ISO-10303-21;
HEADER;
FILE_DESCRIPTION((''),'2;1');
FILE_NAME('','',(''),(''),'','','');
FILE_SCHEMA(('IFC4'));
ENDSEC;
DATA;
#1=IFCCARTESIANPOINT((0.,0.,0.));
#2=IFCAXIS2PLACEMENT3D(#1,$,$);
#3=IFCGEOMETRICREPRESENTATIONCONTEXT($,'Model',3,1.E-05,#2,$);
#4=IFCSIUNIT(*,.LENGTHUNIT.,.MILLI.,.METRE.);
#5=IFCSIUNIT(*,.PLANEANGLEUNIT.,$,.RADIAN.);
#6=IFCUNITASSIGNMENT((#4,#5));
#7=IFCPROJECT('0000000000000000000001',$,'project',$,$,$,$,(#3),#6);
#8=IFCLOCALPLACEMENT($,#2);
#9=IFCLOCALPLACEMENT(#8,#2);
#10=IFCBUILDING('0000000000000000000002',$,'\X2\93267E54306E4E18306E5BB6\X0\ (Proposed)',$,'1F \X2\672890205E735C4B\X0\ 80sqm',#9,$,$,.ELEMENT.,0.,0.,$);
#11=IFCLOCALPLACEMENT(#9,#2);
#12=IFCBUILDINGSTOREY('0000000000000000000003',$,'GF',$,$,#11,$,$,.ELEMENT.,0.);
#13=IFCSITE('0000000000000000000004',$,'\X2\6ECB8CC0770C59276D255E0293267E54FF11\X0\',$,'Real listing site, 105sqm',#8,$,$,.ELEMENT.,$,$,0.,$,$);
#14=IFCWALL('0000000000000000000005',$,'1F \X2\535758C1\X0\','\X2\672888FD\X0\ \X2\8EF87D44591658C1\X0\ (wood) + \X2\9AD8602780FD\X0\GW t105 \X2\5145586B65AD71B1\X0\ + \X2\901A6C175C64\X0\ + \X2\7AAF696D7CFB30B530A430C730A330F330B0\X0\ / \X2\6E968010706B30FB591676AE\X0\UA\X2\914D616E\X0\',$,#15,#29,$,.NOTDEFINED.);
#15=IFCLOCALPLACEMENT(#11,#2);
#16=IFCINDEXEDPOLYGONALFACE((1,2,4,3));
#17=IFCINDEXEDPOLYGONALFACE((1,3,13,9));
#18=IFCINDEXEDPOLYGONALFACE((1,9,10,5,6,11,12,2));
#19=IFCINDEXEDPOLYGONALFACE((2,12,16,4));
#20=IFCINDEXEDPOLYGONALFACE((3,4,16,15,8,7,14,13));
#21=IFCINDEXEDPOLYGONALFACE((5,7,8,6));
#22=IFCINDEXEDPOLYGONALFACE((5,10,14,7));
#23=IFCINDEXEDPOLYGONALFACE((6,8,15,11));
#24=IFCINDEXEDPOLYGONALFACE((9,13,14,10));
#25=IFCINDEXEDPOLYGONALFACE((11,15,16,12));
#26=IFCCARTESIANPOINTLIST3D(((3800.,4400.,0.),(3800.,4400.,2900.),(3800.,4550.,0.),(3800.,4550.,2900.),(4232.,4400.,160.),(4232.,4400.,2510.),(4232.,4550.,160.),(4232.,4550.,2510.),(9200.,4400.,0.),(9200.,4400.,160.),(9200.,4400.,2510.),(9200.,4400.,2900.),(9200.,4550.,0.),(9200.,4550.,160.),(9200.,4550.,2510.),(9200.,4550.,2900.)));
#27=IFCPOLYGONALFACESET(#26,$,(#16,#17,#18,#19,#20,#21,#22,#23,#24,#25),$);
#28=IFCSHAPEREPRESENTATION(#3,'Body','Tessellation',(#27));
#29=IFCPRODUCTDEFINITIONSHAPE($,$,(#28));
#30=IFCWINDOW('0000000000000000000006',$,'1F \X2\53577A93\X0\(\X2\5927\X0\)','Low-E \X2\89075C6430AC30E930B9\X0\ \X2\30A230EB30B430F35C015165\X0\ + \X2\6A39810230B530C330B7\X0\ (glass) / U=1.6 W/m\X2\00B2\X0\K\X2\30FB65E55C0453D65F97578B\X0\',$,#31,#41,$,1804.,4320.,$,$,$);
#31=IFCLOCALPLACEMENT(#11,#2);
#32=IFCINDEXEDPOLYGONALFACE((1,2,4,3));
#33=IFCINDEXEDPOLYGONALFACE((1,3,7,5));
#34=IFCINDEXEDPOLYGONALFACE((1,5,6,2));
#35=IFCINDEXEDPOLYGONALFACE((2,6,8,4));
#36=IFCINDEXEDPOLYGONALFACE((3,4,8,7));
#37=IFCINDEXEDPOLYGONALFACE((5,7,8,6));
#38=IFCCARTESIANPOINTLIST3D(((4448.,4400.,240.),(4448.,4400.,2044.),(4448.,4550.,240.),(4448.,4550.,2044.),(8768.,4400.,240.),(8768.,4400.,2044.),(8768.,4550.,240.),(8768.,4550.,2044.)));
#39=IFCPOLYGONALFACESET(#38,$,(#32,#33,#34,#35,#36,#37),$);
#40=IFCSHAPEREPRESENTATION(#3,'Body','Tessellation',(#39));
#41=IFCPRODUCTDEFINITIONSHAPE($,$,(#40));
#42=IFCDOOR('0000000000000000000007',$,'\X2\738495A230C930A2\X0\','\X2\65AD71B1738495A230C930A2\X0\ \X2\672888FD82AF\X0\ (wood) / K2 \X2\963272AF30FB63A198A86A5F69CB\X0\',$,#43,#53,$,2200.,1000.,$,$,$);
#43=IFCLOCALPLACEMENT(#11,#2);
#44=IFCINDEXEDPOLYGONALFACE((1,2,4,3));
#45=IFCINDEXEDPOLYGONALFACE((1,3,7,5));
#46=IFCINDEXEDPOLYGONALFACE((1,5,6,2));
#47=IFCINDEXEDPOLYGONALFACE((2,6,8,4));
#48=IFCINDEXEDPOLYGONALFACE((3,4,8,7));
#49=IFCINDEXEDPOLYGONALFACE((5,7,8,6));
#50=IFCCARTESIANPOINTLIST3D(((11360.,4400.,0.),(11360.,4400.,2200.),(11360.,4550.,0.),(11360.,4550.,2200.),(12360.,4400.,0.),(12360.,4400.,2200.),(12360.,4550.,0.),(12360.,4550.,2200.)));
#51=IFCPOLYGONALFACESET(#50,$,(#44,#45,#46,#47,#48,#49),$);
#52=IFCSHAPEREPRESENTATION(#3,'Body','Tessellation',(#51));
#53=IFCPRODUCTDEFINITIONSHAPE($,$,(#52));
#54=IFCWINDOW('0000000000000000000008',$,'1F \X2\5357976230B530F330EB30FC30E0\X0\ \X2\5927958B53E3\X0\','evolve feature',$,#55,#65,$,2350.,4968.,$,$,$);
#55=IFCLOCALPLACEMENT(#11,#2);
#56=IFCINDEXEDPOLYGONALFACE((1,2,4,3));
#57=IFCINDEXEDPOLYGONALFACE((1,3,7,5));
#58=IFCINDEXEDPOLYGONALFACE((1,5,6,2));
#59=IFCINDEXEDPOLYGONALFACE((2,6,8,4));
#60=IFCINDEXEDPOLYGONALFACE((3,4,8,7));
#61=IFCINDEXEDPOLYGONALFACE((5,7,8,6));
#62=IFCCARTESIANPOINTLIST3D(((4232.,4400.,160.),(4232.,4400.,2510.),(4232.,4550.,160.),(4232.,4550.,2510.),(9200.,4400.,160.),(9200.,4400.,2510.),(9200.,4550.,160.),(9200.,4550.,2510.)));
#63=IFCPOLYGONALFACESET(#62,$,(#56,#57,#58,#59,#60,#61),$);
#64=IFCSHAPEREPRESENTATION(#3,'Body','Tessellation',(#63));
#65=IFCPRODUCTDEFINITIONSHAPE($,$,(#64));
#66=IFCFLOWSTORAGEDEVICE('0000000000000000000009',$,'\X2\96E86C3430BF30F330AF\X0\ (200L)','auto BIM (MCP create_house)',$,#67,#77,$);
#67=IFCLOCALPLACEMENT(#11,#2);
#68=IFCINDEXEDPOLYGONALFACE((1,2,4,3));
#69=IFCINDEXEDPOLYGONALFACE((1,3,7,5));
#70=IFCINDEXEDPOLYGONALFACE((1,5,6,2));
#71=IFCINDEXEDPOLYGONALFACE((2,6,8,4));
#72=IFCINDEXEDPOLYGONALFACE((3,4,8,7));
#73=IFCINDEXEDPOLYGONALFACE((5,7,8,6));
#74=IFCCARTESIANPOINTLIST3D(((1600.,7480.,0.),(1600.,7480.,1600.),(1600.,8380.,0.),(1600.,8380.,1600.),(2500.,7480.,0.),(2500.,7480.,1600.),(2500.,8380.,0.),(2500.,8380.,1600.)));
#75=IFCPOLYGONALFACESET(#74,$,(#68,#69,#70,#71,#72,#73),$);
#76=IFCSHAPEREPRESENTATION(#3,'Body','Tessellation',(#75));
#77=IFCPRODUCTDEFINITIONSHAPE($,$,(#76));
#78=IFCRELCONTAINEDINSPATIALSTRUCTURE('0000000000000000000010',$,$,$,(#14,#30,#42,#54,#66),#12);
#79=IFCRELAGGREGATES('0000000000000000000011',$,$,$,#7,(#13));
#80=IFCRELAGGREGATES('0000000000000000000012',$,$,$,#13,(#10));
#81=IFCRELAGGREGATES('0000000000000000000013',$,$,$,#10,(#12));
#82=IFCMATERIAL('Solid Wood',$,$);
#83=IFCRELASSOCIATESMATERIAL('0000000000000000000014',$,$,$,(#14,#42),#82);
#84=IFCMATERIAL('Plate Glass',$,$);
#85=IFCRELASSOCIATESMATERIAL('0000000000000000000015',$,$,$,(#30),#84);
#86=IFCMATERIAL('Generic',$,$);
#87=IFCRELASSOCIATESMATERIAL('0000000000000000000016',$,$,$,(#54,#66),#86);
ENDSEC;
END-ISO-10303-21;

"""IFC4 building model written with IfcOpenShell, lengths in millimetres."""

from ifc_helpers import new_model, si_unit, frame, frame_2d, origin, place, context, project, spatial, rectangle, extrude, material, element, fill, save


model = new_model("IFC4")

# Units and contexts
model_context = context("Model", 3, precision=1e-05, world=origin())
ifc_project = project(units=[si_unit("LENGTHUNIT", "METRE", prefix="MILLI"), si_unit("PLANEANGLEUNIT", "RADIAN")], contexts=[model_context])

# Site, building, storey
site_placement = place(None, origin())
site = spatial("IfcSite", under=ifc_project, at=site_placement, Name="滋賀県大津市錦織１", ObjectType="Real listing site, 105sqm", CompositionType="ELEMENT", RefElevation=0.0)
building_placement = place(site_placement, origin())
building = spatial("IfcBuilding", under=site, at=building_placement, Name="錦織の丘の家 (Proposed)", ObjectType="1F 木造平屋 80sqm", CompositionType="ELEMENT", ElevationOfRefHeight=0.0, ElevationOfTerrain=0.0)
storey_placement = place(building_placement, origin())
storey = spatial("IfcBuildingStorey", under=building, at=storey_placement, Name="GF", CompositionType="ELEMENT", Elevation=0.0)

# Shared definitions
ifc_material_1 = material(Name="Solid Wood")

# Wall, openings, windows, door
wall_1_placement = place(storey_placement, frame((1900.0, 2200.0, 0.0)))
wall_1 = element("IfcWall", 1, at=wall_1_placement, inside=storey, material=ifc_material_1, Name="1F 南壁", Description="木製 軸組外壁 (wood) + 高性能GW t105 充填断熱 + 通気層 + 窯業系サイディング / 準耐火・外皮UA配慮", PredefinedType="NOTDEFINED", context=model_context, shape_type="SweptSolid", body=[
    extrude(rectangle(XDim=5400.0, YDim=150.0, at=frame_2d((2700.0, 75.0))), frame((1900.0, 2200.0, 0.0)), (0.0, 0.0, 1.0), 2900.0),
])
opening_1_placement = place(storey_placement, frame((2224.0, 2200.0, 120.0)))
opening_1 = element("IfcOpeningElement", 2, at=opening_1_placement, cuts=wall_1, PredefinedType="NOTDEFINED", context=model_context, shape_type="SweptSolid", body=[
    extrude(rectangle(XDim=4320.0, YDim=150.0, at=frame_2d((2160.0, 75.0))), frame((2224.0, 2200.0, 120.0)), (0.0, 0.0, 1.0), 1804.0),
])
opening_2_placement = place(storey_placement, frame((5680.0, 2200.0, 0.0)))
opening_2 = element("IfcOpeningElement", 3, at=opening_2_placement, cuts=wall_1, PredefinedType="NOTDEFINED", context=model_context, shape_type="SweptSolid", body=[
    extrude(rectangle(XDim=1000.0, YDim=150.0, at=frame_2d((500.0, 75.0))), frame((5680.0, 2200.0, 0.0)), (0.0, 0.0, 1.0), 2200.0),
])
opening_3_placement = place(storey_placement, frame((2116.0, 2200.0, 80.0)))
opening_3 = element("IfcOpeningElement", 4, at=opening_3_placement, cuts=wall_1, PredefinedType="NOTDEFINED", context=model_context, shape_type="SweptSolid", body=[
    extrude(rectangle(XDim=4968.0, YDim=150.0, at=frame_2d((2484.0, 75.0))), frame((2116.0, 2200.0, 80.0)), (0.0, 0.0, 1.0), 2350.0),
])
ifc_material_2 = material(Name="Plate Glass")
window_1_placement = place(storey_placement, frame((2224.0, 2200.0, 120.0)))
window_1 = element("IfcWindow", 5, at=window_1_placement, inside=storey, material=ifc_material_2, Name="1F 南窓(大)", Description="Low-E 複層ガラス アルゴン封入 + 樹脂サッシ (glass) / U=1.6 W/m²K・日射取得型", OverallHeight=1804.0, OverallWidth=4320.0, context=model_context, shape_type="SweptSolid", body=[
    extrude(rectangle(XDim=4320.0, YDim=150.0, at=frame_2d((2160.0, 75.0))), frame((2224.0, 2200.0, 120.0)), (0.0, 0.0, 1.0), 1804.0),
])
fill(opening_1, window_1)
door_1_placement = place(storey_placement, frame((5680.0, 2200.0, 0.0)))
door_1 = element("IfcDoor", 6, at=door_1_placement, inside=storey, material=ifc_material_1, Name="玄関ドア", Description="断熱玄関ドア 木製芯 (wood) / K2 防犯・採風機構", OverallHeight=2200.0, OverallWidth=1000.0, context=model_context, shape_type="SweptSolid", body=[
    extrude(rectangle(XDim=1000.0, YDim=150.0, at=frame_2d((500.0, 75.0))), frame((5680.0, 2200.0, 0.0)), (0.0, 0.0, 1.0), 2200.0),
])
fill(opening_2, door_1)
ifc_material_3 = material(Name="Generic")
window_2_placement = place(storey_placement, frame((2116.0, 2200.0, 80.0)))
window_2 = element("IfcWindow", 7, at=window_2_placement, inside=storey, material=ifc_material_3, Name="1F 南面サンルーム 大開口", Description="evolve feature", OverallHeight=2350.0, OverallWidth=4968.0, context=model_context, shape_type="SweptSolid", body=[
    extrude(rectangle(XDim=4968.0, YDim=150.0, at=frame_2d((2484.0, 75.0))), frame((2116.0, 2200.0, 80.0)), (0.0, 0.0, 1.0), 2350.0),
])
fill(opening_3, window_2)

# Flow storage device
flow_storage_device_placement = place(storey_placement, frame((800.0, 3740.0, 0.0)))
element("IfcFlowStorageDevice", 8, at=flow_storage_device_placement, inside=storey, material=ifc_material_3, Name="雨水タンク (200L)", Description="auto BIM (MCP create_house)", context=model_context, shape_type="SweptSolid", body=[
    extrude(rectangle(XDim=900.0, YDim=900.0, at=frame_2d((450.0, 450.0))), frame((800.0, 3740.0, 0.0)), (0.0, 0.0, 1.0), 1600.0),
])

save(model, "model.ifc")
